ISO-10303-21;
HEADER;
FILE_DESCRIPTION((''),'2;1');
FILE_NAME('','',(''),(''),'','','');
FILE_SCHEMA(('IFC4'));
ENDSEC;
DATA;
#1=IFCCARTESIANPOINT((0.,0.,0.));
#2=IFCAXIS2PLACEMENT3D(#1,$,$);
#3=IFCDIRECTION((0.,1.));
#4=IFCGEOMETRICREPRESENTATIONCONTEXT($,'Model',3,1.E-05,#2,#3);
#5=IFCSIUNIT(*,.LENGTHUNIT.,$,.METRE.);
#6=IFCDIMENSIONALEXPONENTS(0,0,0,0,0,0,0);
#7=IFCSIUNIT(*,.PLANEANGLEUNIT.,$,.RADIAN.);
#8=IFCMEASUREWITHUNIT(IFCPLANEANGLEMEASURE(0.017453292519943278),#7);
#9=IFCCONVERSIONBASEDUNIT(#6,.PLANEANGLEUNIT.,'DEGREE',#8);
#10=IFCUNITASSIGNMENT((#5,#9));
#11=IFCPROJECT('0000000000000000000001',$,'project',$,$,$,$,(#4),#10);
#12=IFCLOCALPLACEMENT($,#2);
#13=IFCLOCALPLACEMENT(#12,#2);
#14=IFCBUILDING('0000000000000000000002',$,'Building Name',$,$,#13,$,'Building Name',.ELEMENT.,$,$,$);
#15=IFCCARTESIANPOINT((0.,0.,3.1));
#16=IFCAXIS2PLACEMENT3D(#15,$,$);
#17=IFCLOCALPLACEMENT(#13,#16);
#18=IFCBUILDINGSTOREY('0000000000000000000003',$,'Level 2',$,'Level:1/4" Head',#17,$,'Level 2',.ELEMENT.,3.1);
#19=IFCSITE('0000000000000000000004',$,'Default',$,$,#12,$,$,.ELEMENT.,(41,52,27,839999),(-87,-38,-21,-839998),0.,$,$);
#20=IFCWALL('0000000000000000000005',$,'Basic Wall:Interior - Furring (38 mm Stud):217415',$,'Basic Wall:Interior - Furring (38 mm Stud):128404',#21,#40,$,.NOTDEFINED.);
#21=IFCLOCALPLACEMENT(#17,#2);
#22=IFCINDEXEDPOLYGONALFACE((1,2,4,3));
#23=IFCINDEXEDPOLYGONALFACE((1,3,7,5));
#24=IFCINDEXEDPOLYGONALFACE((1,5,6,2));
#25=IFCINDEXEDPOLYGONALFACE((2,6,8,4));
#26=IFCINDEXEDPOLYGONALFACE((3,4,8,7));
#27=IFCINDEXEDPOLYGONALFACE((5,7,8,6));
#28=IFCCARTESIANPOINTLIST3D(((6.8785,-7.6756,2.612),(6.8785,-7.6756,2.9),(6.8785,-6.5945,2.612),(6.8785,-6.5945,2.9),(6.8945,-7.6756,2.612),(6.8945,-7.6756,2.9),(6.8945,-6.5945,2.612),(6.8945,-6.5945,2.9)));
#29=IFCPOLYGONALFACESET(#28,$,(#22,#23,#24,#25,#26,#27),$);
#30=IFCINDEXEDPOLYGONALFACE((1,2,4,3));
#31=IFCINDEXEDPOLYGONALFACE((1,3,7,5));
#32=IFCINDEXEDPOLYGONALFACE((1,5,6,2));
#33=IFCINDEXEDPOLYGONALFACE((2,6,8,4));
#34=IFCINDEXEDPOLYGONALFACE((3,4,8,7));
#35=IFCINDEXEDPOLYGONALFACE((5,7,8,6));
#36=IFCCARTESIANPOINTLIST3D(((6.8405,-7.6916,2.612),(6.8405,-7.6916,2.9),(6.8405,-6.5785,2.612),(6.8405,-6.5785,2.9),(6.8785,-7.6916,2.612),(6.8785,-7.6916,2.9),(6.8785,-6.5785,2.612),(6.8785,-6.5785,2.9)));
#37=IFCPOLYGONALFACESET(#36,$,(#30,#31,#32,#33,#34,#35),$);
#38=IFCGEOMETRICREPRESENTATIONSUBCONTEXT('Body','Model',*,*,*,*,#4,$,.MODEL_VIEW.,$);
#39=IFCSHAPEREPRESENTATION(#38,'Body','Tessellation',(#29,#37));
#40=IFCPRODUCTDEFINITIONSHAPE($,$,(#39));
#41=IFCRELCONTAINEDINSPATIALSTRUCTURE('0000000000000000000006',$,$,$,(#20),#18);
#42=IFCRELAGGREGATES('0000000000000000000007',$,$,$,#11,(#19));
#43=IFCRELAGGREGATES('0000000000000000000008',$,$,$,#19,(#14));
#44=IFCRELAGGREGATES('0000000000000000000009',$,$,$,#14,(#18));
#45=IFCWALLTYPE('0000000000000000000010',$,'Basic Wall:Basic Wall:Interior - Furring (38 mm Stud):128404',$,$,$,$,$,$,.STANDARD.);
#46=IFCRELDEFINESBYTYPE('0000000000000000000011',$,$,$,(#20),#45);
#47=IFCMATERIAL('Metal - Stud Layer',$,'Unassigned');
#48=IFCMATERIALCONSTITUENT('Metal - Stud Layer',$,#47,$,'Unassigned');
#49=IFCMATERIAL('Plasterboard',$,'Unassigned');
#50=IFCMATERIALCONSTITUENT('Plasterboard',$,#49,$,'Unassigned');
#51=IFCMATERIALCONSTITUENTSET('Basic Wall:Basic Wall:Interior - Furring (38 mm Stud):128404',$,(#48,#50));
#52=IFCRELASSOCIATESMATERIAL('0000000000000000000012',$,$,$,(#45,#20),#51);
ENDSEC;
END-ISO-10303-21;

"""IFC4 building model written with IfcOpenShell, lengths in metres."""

from ifc_helpers import new_model, entity, si_unit, converted_unit, direction, frame, origin, place, context, subcontext, project, spatial, indexed_curve, outline, extrude, material, constituent, constituent_set, type_object, element, save


model = new_model("IFC4")

# Units and contexts
model_context = context("Model", 3, precision=1e-05, world=origin(), true_north=direction((0.0, 1.0)))
body_context = subcontext(model_context, "Body", "Model", "MODEL_VIEW")
ifc_project = project(units=[si_unit("LENGTHUNIT", "METRE"), converted_unit("PLANEANGLEUNIT", "DEGREE", entity("IfcPlaneAngleMeasure", 0.017453292519943278), si_unit("PLANEANGLEUNIT", "RADIAN"), dimensions=[0, 0, 0, 0, 0, 0, 0])], contexts=[model_context])

# Site, building, storey
site_placement = place(None, origin())
site = spatial("IfcSite", under=ifc_project, at=site_placement, Name="Default", CompositionType="ELEMENT", RefLatitude=(41, 52, 27, 839999), RefLongitude=(-87, -38, -21, -839998), RefElevation=0.0)
building_placement = place(site_placement, origin())
building = spatial("IfcBuilding", under=site, at=building_placement, Name="Building Name", LongName="Building Name", CompositionType="ELEMENT")
storey_placement = place(building_placement, frame((0.0, 0.0, 3.1)))
storey = spatial("IfcBuildingStorey", under=building, at=storey_placement, Name="Level 2", ObjectType="Level:1/4\" Head", LongName="Level 2", CompositionType="ELEMENT", Elevation=3.1)

# Shared definitions
ifc_material_1 = material(Name="Plasterboard", Category="Unassigned")
ifc_material_2 = material(Name="Metal - Stud Layer", Category="Unassigned")

# Wall
ifc_constituent_1 = constituent(ifc_material_2, Name="Metal - Stud Layer", Category="Unassigned")
ifc_constituent_2 = constituent(ifc_material_1, Name="Plasterboard", Category="Unassigned")
ifc_constituent_set_1 = constituent_set(constituents=[ifc_constituent_1, ifc_constituent_2], Name="Basic Wall:Basic Wall:Interior - Furring (38 mm Stud):128404")
wall_type_1 = type_object("IfcWallType", Name="Basic Wall:Basic Wall:Interior - Furring (38 mm Stud):128404", PredefinedType="STANDARD", material=ifc_constituent_set_1)
wall_1_placement = place(storey_placement, frame((6.8675, -7.6756, 2.612), z_axis=(0.0, 0.0, 1.0), x_axis=(0.0, 1.0, 0.0)))
element("IfcWall", 1, at=wall_1_placement, inside=storey, type_object=wall_type_1, material=ifc_constituent_set_1, Name="Basic Wall:Interior - Furring (38 mm Stud):217415", ObjectType="Basic Wall:Interior - Furring (38 mm Stud):128404", PredefinedType="NOTDEFINED", context=body_context, shape_type="SweptSolid", body=[
    extrude(outline(indexed_curve([(-0.008, -0.5405), (0.008, -0.5405), (0.008, 0.5405), (-0.008, 0.5405), (-0.008, -0.5405)], self_intersect=False)), frame((0.5405, -0.019, 0.0), z_axis=(0.0, 0.0, 1.0), x_axis=(0.0, 1.0, 0.0)), (0.0, 0.0, 1.0), 0.288),
    extrude(outline(indexed_curve([(-0.019, -0.5565), (0.019, -0.5565), (0.019, 0.5565), (-0.019, 0.5565), (-0.019, -0.5565)], self_intersect=False)), frame((0.5405, 0.008, 0.0), z_axis=(0.0, 0.0, 1.0), x_axis=(0.0, -1.0, 0.0)), (0.0, 0.0, 1.0), 0.288),
])

save(model, "model.ifc")
